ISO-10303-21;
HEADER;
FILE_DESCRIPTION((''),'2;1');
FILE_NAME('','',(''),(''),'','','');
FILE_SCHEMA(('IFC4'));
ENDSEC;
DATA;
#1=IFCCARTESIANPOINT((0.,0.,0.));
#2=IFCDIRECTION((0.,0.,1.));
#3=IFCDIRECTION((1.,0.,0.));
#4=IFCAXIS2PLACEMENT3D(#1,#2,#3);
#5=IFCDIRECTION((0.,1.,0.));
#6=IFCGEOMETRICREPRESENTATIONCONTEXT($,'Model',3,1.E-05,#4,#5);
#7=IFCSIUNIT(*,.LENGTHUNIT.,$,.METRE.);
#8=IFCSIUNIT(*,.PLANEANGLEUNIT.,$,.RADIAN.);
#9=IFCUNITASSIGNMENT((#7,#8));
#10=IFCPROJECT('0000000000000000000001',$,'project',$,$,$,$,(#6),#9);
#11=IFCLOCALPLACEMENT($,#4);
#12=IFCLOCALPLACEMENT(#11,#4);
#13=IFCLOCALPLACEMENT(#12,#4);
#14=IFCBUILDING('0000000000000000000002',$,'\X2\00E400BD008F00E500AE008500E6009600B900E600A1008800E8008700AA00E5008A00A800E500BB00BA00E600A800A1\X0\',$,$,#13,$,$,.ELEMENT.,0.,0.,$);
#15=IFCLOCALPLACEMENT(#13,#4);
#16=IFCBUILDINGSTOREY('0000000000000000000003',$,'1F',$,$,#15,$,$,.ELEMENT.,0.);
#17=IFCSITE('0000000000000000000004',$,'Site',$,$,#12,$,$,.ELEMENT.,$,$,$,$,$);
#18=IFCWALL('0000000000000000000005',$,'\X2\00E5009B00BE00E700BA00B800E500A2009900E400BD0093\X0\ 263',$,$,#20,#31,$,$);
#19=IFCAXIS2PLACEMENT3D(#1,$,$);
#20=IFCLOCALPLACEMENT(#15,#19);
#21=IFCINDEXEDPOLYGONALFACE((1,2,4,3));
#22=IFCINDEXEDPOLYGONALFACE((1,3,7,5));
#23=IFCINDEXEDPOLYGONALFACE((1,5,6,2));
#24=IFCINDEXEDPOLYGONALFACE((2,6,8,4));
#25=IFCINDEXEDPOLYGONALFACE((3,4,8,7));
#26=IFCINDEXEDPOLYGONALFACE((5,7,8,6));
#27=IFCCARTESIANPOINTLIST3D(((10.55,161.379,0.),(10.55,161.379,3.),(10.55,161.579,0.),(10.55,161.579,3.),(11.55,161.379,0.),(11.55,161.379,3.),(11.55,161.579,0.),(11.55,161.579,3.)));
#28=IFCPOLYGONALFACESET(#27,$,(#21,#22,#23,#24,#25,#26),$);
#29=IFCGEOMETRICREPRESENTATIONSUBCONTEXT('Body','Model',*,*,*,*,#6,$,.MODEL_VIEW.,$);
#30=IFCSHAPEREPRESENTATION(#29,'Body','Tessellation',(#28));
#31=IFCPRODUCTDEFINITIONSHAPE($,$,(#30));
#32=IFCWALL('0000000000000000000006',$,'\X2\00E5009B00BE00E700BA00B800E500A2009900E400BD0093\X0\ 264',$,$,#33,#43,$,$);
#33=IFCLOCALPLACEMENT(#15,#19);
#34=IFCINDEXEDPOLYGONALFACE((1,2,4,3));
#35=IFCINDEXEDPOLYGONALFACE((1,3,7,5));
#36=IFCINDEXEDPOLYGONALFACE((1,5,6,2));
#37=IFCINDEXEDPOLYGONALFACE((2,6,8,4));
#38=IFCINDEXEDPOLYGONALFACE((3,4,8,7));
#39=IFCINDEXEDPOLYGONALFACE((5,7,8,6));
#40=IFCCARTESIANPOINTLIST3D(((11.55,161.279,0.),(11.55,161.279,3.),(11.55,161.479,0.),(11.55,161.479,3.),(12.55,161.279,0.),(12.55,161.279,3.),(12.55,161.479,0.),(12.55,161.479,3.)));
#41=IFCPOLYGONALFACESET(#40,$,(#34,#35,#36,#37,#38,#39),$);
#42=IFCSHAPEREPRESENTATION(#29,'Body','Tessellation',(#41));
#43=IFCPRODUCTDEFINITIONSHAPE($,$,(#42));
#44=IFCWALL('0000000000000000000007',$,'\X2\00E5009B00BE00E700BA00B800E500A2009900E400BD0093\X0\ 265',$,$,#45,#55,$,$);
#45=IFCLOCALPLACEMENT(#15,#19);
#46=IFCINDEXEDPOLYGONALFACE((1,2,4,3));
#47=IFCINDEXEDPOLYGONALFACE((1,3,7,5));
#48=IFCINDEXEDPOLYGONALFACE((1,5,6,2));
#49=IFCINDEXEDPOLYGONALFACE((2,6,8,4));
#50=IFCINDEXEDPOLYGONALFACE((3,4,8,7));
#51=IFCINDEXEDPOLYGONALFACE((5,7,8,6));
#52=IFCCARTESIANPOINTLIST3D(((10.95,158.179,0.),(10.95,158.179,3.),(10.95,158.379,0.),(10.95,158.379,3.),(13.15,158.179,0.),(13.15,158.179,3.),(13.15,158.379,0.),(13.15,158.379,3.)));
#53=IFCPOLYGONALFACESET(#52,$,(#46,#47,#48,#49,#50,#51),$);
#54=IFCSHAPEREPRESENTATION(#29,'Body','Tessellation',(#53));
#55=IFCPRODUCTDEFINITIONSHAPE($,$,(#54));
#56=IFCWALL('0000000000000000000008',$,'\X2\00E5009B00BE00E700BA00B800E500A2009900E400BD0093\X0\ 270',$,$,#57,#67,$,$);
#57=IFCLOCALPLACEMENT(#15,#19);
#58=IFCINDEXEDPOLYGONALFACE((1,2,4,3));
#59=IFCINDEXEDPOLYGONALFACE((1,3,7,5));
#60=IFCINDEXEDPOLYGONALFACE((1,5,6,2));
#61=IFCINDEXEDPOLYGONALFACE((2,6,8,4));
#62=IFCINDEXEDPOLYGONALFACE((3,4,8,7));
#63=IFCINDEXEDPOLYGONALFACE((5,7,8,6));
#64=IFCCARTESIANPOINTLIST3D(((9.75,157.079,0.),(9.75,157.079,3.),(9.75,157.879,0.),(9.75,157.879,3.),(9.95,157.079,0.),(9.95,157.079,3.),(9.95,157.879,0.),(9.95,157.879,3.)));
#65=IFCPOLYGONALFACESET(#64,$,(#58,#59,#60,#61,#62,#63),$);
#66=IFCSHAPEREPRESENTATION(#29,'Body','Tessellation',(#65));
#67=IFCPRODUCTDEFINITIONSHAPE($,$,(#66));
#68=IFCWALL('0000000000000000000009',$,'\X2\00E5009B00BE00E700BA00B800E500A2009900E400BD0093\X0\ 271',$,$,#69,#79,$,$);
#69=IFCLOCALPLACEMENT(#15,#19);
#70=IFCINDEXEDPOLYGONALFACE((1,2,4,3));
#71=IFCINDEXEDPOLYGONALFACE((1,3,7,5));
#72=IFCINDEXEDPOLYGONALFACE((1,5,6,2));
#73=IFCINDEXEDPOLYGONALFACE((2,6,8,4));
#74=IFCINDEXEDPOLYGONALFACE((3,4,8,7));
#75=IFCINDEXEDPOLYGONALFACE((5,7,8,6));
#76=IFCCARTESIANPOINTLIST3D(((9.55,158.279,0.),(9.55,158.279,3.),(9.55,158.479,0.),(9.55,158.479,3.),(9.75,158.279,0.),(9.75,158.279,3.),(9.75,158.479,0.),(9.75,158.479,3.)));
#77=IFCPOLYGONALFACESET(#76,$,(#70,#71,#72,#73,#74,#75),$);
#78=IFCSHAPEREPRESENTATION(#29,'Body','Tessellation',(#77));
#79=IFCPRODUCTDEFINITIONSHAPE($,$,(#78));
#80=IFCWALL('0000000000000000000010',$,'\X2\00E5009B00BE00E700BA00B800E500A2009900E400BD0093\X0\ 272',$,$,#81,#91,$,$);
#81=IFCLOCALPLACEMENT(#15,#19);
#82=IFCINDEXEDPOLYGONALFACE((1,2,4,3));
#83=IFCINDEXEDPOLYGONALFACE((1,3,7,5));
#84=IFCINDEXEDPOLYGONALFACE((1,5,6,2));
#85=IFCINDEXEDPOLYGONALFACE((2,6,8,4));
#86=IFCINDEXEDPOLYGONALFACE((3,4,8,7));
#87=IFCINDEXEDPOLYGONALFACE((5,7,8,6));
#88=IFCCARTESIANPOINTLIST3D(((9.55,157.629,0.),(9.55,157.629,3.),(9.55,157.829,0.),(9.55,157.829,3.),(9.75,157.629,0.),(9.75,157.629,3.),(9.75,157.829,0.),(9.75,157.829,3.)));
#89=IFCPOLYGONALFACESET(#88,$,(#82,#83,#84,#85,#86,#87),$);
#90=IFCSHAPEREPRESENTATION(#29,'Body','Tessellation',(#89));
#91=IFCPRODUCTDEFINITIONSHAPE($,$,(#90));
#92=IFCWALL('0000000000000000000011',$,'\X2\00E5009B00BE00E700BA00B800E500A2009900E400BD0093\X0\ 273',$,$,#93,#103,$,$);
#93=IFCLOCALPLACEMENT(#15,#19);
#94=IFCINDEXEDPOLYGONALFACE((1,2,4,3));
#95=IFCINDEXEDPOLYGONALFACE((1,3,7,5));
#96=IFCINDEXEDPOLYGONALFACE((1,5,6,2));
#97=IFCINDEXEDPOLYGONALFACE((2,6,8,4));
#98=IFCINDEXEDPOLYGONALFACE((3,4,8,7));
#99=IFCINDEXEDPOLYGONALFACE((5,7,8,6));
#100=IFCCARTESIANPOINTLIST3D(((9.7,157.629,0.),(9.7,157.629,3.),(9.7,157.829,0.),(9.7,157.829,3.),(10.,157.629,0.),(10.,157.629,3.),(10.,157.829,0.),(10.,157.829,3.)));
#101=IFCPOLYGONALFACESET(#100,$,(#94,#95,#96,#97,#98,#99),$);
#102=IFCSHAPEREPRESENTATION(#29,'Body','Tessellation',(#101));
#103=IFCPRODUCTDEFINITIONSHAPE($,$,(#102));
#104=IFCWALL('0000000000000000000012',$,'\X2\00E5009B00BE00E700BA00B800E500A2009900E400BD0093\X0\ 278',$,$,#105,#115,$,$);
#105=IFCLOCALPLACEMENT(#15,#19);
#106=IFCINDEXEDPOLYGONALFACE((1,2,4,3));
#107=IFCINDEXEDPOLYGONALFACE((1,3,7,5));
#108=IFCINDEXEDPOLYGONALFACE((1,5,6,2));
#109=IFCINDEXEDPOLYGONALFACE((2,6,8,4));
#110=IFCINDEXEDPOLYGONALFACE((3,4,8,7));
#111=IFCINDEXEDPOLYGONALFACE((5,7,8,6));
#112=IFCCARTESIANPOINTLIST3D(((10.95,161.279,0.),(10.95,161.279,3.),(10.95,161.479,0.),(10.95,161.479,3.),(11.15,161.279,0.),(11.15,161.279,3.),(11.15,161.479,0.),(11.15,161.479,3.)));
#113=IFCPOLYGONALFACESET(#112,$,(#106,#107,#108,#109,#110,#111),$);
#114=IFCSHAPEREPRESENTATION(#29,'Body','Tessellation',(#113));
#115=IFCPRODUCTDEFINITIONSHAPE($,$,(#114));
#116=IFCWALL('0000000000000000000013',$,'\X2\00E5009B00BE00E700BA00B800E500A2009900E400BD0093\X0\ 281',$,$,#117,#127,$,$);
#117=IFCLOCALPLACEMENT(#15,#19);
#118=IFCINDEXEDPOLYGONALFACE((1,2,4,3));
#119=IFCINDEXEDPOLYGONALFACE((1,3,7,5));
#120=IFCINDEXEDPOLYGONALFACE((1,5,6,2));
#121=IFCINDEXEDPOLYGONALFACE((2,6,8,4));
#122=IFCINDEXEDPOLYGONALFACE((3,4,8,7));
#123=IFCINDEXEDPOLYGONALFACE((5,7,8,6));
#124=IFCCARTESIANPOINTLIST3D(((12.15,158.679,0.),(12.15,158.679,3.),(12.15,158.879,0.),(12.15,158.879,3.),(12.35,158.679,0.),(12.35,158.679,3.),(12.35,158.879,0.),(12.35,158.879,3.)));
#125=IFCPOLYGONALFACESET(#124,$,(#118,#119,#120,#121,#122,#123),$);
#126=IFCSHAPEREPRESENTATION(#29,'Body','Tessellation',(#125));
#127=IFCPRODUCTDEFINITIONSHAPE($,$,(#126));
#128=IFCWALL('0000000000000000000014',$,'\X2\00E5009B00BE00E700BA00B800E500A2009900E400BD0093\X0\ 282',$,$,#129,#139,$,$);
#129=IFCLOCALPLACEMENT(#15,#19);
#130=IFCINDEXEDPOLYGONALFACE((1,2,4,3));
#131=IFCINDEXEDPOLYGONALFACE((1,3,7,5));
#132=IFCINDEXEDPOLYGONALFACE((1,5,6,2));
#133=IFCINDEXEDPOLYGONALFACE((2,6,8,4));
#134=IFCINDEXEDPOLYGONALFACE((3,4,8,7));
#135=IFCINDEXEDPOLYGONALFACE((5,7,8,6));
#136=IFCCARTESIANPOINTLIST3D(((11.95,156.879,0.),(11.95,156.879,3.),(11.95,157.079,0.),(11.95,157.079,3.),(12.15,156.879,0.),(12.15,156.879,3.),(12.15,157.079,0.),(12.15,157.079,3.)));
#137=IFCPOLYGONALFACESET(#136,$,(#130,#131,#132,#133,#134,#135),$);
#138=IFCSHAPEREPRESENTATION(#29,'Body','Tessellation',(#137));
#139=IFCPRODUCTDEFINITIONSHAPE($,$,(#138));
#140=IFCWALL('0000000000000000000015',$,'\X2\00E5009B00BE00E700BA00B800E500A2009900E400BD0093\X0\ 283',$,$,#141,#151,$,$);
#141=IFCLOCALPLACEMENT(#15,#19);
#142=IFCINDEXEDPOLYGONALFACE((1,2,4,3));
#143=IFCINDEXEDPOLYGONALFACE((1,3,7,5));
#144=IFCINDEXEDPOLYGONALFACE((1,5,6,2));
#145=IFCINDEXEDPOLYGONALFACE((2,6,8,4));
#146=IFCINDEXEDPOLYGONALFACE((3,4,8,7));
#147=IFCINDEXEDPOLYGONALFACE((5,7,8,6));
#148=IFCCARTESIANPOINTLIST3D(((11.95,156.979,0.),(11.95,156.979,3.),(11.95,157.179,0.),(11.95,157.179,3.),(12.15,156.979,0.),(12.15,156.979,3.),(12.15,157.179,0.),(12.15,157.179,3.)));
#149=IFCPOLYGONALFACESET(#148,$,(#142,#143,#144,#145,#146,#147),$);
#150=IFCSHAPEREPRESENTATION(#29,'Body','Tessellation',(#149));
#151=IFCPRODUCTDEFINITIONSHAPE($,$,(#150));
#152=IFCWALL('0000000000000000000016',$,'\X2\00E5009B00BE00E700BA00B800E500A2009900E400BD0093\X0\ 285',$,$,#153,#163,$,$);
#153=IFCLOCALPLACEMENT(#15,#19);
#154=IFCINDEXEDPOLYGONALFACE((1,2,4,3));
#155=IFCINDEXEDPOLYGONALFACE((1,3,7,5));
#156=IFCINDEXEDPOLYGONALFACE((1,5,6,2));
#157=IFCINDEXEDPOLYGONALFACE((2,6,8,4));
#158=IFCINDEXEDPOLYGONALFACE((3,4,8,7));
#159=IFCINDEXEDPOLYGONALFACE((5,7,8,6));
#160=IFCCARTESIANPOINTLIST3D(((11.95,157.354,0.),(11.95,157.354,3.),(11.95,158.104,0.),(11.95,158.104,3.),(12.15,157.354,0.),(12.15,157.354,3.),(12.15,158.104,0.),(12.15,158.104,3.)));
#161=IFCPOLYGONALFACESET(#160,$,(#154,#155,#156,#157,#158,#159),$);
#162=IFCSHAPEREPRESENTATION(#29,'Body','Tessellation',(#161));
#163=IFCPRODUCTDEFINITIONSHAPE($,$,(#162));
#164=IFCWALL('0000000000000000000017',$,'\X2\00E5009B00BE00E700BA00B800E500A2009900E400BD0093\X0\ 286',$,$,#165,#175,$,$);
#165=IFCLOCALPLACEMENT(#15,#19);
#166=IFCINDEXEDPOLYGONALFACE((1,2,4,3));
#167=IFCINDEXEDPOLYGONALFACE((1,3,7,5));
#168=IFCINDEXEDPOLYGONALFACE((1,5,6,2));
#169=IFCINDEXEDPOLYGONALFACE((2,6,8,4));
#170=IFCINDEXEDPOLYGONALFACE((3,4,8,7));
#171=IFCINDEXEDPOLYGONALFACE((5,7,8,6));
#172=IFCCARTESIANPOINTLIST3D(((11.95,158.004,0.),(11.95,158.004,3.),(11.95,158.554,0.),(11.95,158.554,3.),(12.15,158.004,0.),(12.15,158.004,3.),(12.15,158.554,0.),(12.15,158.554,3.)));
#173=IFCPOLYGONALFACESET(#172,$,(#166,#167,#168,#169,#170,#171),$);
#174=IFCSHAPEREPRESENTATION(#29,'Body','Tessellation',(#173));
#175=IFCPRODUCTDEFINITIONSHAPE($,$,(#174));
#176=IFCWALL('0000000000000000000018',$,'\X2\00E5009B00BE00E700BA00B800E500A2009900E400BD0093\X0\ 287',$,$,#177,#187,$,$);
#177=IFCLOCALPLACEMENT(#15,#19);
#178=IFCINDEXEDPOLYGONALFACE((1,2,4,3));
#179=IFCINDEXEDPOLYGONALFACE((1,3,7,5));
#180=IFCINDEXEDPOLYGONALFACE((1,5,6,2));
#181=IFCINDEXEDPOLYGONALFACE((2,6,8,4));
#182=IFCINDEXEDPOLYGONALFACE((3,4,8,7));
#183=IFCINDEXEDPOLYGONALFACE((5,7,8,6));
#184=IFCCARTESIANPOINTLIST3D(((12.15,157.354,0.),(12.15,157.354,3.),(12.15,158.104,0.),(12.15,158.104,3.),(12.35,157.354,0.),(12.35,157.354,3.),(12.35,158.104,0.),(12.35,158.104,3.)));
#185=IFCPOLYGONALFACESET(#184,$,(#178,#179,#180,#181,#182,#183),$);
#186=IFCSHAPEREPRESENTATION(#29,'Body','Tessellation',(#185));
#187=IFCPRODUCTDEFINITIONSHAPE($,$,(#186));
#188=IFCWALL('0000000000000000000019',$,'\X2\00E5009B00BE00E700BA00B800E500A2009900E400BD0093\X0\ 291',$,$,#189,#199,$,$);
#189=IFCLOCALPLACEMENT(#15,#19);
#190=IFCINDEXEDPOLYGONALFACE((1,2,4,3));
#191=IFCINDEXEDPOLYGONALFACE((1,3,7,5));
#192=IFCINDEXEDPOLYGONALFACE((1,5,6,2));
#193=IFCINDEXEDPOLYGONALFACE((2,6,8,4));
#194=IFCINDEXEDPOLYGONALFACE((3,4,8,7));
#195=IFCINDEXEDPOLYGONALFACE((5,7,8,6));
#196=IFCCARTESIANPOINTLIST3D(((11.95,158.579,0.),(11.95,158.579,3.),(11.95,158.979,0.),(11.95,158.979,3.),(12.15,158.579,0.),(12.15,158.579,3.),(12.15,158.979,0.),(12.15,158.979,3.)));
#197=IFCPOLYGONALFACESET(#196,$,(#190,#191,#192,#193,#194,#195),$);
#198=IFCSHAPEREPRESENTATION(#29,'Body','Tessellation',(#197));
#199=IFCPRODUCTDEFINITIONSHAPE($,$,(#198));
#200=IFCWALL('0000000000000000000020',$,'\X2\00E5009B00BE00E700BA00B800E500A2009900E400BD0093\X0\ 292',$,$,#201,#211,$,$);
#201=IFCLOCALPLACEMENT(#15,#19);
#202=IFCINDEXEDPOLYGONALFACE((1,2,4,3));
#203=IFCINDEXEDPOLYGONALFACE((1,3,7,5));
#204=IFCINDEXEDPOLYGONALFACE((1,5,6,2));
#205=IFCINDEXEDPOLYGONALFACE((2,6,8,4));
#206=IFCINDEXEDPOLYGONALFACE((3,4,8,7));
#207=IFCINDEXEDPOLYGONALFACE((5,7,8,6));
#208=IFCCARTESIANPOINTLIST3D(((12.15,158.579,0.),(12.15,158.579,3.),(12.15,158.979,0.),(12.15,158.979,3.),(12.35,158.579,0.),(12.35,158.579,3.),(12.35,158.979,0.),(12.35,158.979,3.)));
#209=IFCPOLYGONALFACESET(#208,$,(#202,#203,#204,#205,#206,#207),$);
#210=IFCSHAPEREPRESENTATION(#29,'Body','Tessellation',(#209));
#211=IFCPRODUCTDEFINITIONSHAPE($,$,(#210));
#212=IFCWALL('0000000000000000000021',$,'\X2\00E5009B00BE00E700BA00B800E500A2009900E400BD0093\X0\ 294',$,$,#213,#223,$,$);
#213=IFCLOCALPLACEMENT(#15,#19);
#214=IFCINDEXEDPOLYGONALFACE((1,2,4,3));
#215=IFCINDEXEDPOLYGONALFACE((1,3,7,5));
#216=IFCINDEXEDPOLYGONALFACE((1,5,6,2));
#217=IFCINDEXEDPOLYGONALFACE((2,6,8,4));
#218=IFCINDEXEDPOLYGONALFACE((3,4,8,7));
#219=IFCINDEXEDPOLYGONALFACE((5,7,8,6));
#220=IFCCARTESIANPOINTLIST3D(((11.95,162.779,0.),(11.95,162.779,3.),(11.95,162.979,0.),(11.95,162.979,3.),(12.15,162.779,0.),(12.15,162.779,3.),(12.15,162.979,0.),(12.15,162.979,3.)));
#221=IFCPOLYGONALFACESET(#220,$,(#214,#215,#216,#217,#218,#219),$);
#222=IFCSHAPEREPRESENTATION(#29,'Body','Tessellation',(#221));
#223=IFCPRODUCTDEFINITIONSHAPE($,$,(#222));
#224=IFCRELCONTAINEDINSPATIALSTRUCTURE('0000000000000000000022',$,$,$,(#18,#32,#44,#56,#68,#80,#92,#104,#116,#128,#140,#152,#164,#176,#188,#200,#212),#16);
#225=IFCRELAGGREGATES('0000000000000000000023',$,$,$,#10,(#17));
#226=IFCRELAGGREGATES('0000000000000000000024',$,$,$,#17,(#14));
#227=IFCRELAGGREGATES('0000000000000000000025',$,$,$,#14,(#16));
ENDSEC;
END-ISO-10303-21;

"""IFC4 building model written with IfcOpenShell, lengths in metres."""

from ifc_helpers import new_model, si_unit, direction, frame, frame_2d, origin_with_axes, place, context, subcontext, project, spatial, rectangle, extrude, element, save


model = new_model("IFC4")

# Units and contexts
model_context = context("Model", 3, precision=1e-05, world=origin_with_axes(), true_north=direction((0.0, 1.0, 0.0)))
body_context = subcontext(model_context, "Body", "Model", "MODEL_VIEW")
ifc_project = project(units=[si_unit("LENGTHUNIT", "METRE"), si_unit("PLANEANGLEUNIT", "RADIAN")], contexts=[model_context])

# Site, building, storey
placement = place(None, origin_with_axes())
site_placement = place(placement, origin_with_axes())
site = spatial("IfcSite", under=ifc_project, at=site_placement, Name="Site", CompositionType="ELEMENT")
building_placement = place(site_placement, origin_with_axes())
building = spatial("IfcBuilding", under=site, at=building_placement, Name="ä½\u008få®\u0085æ\u0096¹æ¡\u0088è\u0087ªå\u008a¨å»ºæ¨¡", CompositionType="ELEMENT", ElevationOfRefHeight=0.0, ElevationOfTerrain=0.0)
storey_placement = place(building_placement, origin_with_axes())
storey = spatial("IfcBuildingStorey", under=building, at=storey_placement, Name="1F", CompositionType="ELEMENT", Elevation=0.0)

# Walls
for number, where, z_axis, x_axis, name in (
    (1, (11.05, 161.479, 0.0), (0.0, 0.0, 1.0), (1.0, 0.0, 0.0), "å\u009b¾çº¸å¢\u0099ä½\u0093 263"),
    (2, (12.05, 161.379, 0.0), (0.0, 0.0, 1.0), (-1.0, 0.0, 0.0), "å\u009b¾çº¸å¢\u0099ä½\u0093 264"),
):
    element("IfcWall", number, at=place(storey_placement, frame(where, z_axis=z_axis, x_axis=x_axis)), inside=storey, Name=name, context=body_context, shape_type="SweptSolid", body=[
        extrude(rectangle(XDim=1.0, YDim=0.2, at=frame_2d((0.0, 0.0), x_axis=(1.0, 0.0, 0.0))), frame((0.0, 0.0, 0.0), z_axis=(0.0, 0.0, 1.0)), (0.0, 0.0, 1.0), 3.0),
    ])
wall_1_placement = place(storey_placement, frame((12.05, 158.279, 0.0), z_axis=(0.0, 0.0, 1.0), x_axis=(-1.0, 0.0, 0.0)))
element("IfcWall", 3, at=wall_1_placement, inside=storey, Name="å\u009b¾çº¸å¢\u0099ä½\u0093 265", context=body_context, shape_type="SweptSolid", body=[
    extrude(rectangle(XDim=2.2, YDim=0.2, at=frame_2d((0.0, 0.0), x_axis=(1.0, 0.0, 0.0))), frame((0.0, 0.0, 0.0), z_axis=(0.0, 0.0, 1.0)), (0.0, 0.0, 1.0), 3.0),
])
wall_2_placement = place(storey_placement, frame((9.85, 157.479, 0.0), z_axis=(0.0, 0.0, 1.0), x_axis=(0.0, 1.0, 0.0)))
element("IfcWall", 4, at=wall_2_placement, inside=storey, Name="å\u009b¾çº¸å¢\u0099ä½\u0093 270", context=body_context, shape_type="SweptSolid", body=[
    extrude(rectangle(XDim=0.8, YDim=0.2, at=frame_2d((0.0, 0.0), x_axis=(1.0, 0.0, 0.0))), frame((0.0, 0.0, 0.0), z_axis=(0.0, 0.0, 1.0)), (0.0, 0.0, 1.0), 3.0),
])
for number, where, z_axis, x_axis, name in (
    (5, (9.65, 158.379, 0.0), (0.0, 0.0, 1.0), (1.0, 0.0, 0.0), "å\u009b¾çº¸å¢\u0099ä½\u0093 271"),
    (6, (9.65, 157.729, 0.0), (0.0, 0.0, 1.0), (1.0, 0.0, 0.0), "å\u009b¾çº¸å¢\u0099ä½\u0093 272"),
):
    element("IfcWall", number, at=place(storey_placement, frame(where, z_axis=z_axis, x_axis=x_axis)), inside=storey, Name=name, context=body_context, shape_type="SweptSolid", body=[
        extrude(rectangle(XDim=0.2, YDim=0.2, at=frame_2d((0.0, 0.0), x_axis=(1.0, 0.0, 0.0))), frame((0.0, 0.0, 0.0), z_axis=(0.0, 0.0, 1.0)), (0.0, 0.0, 1.0), 3.0),
    ])
wall_3_placement = place(storey_placement, frame((9.85, 157.729, 0.0), z_axis=(0.0, 0.0, 1.0), x_axis=(-1.0, 0.0, 0.0)))
element("IfcWall", 7, at=wall_3_placement, inside=storey, Name="å\u009b¾çº¸å¢\u0099ä½\u0093 273", context=body_context, shape_type="SweptSolid", body=[
    extrude(rectangle(XDim=0.3, YDim=0.2, at=frame_2d((0.0, 0.0), x_axis=(1.0, 0.0, 0.0))), frame((0.0, 0.0, 0.0), z_axis=(0.0, 0.0, 1.0)), (0.0, 0.0, 1.0), 3.0),
])
for number, where, z_axis, x_axis, name in (
    (8, (11.05, 161.379, 0.0), (0.0, 0.0, 1.0), (0.0, 1.0, 0.0), "å\u009b¾çº¸å¢\u0099ä½\u0093 278"),
    (9, (12.25, 158.779, 0.0), (0.0, 0.0, 1.0), (-1.0, 0.0, 0.0), "å\u009b¾çº¸å¢\u0099ä½\u0093 281"),
    (10, (12.05, 156.979, 0.0), (0.0, 0.0, 1.0), (1.0, 0.0, 0.0), "å\u009b¾çº¸å¢\u0099ä½\u0093 282"),
    (11, (12.05, 157.079, 0.0), (0.0, 0.0, 1.0), (1.0, 0.0, 0.0), "å\u009b¾çº¸å¢\u0099ä½\u0093 283"),
):
    element("IfcWall", number, at=place(storey_placement, frame(where, z_axis=z_axis, x_axis=x_axis)), inside=storey, Name=name, context=body_context, shape_type="SweptSolid", body=[
        extrude(rectangle(XDim=0.2, YDim=0.2, at=frame_2d((0.0, 0.0), x_axis=(1.0, 0.0, 0.0))), frame((0.0, 0.0, 0.0), z_axis=(0.0, 0.0, 1.0)), (0.0, 0.0, 1.0), 3.0),
    ])
wall_4_placement = place(storey_placement, frame((12.05, 157.729, 0.0), z_axis=(0.0, 0.0, 1.0), x_axis=(0.0, -1.0, 0.0)))
element("IfcWall", 12, at=wall_4_placement, inside=storey, Name="å\u009b¾çº¸å¢\u0099ä½\u0093 285", context=body_context, shape_type="SweptSolid", body=[
    extrude(rectangle(XDim=0.75, YDim=0.2, at=frame_2d((0.0, 0.0), x_axis=(1.0, 0.0, 0.0))), frame((0.0, 0.0, 0.0), z_axis=(0.0, 0.0, 1.0)), (0.0, 0.0, 1.0), 3.0),
])
wall_5_placement = place(storey_placement, frame((12.05, 158.279, 0.0), z_axis=(0.0, 0.0, 1.0), x_axis=(0.0, -1.0, 0.0)))
element("IfcWall", 13, at=wall_5_placement, inside=storey, Name="å\u009b¾çº¸å¢\u0099ä½\u0093 286", context=body_context, shape_type="SweptSolid", body=[
    extrude(rectangle(XDim=0.55, YDim=0.2, at=frame_2d((0.0, 0.0), x_axis=(1.0, 0.0, 0.0))), frame((0.0, 0.0, 0.0), z_axis=(0.0, 0.0, 1.0)), (0.0, 0.0, 1.0), 3.0),
])
wall_6_placement = place(storey_placement, frame((12.25, 157.729, 0.0), z_axis=(0.0, 0.0, 1.0), x_axis=(0.0, -1.0, 0.0)))
element("IfcWall", 14, at=wall_6_placement, inside=storey, Name="å\u009b¾çº¸å¢\u0099ä½\u0093 287", context=body_context, shape_type="SweptSolid", body=[
    extrude(rectangle(XDim=0.75, YDim=0.2, at=frame_2d((0.0, 0.0), x_axis=(1.0, 0.0, 0.0))), frame((0.0, 0.0, 0.0), z_axis=(0.0, 0.0, 1.0)), (0.0, 0.0, 1.0), 3.0),
])
for number, where, z_axis, x_axis, name in (
    (15, (12.05, 158.779, 0.0), (0.0, 0.0, 1.0), (0.0, -1.0, 0.0), "å\u009b¾çº¸å¢\u0099ä½\u0093 291"),
    (16, (12.25, 158.779, 0.0), (0.0, 0.0, 1.0), (0.0, -1.0, 0.0), "å\u009b¾çº¸å¢\u0099ä½\u0093 292"),
):
    element("IfcWall", number, at=place(storey_placement, frame(where, z_axis=z_axis, x_axis=x_axis)), inside=storey, Name=name, context=body_context, shape_type="SweptSolid", body=[
        extrude(rectangle(XDim=0.4, YDim=0.2, at=frame_2d((0.0, 0.0), x_axis=(1.0, 0.0, 0.0))), frame((0.0, 0.0, 0.0), z_axis=(0.0, 0.0, 1.0)), (0.0, 0.0, 1.0), 3.0),
    ])
for number, where, z_axis, x_axis, name in (
    (17, (12.05, 162.879, 0.0), (0.0, 0.0, 1.0), (1.0, 0.0, 0.0), "å\u009b¾çº¸å¢\u0099ä½\u0093 294"),
):
    element("IfcWall", number, at=place(storey_placement, frame(where, z_axis=z_axis, x_axis=x_axis)), inside=storey, Name=name, context=body_context, shape_type="SweptSolid", body=[
        extrude(rectangle(XDim=0.2, YDim=0.2, at=frame_2d((0.0, 0.0), x_axis=(1.0, 0.0, 0.0))), frame((0.0, 0.0, 0.0), z_axis=(0.0, 0.0, 1.0)), (0.0, 0.0, 1.0), 3.0),
    ])

save(model, "model.ifc")
